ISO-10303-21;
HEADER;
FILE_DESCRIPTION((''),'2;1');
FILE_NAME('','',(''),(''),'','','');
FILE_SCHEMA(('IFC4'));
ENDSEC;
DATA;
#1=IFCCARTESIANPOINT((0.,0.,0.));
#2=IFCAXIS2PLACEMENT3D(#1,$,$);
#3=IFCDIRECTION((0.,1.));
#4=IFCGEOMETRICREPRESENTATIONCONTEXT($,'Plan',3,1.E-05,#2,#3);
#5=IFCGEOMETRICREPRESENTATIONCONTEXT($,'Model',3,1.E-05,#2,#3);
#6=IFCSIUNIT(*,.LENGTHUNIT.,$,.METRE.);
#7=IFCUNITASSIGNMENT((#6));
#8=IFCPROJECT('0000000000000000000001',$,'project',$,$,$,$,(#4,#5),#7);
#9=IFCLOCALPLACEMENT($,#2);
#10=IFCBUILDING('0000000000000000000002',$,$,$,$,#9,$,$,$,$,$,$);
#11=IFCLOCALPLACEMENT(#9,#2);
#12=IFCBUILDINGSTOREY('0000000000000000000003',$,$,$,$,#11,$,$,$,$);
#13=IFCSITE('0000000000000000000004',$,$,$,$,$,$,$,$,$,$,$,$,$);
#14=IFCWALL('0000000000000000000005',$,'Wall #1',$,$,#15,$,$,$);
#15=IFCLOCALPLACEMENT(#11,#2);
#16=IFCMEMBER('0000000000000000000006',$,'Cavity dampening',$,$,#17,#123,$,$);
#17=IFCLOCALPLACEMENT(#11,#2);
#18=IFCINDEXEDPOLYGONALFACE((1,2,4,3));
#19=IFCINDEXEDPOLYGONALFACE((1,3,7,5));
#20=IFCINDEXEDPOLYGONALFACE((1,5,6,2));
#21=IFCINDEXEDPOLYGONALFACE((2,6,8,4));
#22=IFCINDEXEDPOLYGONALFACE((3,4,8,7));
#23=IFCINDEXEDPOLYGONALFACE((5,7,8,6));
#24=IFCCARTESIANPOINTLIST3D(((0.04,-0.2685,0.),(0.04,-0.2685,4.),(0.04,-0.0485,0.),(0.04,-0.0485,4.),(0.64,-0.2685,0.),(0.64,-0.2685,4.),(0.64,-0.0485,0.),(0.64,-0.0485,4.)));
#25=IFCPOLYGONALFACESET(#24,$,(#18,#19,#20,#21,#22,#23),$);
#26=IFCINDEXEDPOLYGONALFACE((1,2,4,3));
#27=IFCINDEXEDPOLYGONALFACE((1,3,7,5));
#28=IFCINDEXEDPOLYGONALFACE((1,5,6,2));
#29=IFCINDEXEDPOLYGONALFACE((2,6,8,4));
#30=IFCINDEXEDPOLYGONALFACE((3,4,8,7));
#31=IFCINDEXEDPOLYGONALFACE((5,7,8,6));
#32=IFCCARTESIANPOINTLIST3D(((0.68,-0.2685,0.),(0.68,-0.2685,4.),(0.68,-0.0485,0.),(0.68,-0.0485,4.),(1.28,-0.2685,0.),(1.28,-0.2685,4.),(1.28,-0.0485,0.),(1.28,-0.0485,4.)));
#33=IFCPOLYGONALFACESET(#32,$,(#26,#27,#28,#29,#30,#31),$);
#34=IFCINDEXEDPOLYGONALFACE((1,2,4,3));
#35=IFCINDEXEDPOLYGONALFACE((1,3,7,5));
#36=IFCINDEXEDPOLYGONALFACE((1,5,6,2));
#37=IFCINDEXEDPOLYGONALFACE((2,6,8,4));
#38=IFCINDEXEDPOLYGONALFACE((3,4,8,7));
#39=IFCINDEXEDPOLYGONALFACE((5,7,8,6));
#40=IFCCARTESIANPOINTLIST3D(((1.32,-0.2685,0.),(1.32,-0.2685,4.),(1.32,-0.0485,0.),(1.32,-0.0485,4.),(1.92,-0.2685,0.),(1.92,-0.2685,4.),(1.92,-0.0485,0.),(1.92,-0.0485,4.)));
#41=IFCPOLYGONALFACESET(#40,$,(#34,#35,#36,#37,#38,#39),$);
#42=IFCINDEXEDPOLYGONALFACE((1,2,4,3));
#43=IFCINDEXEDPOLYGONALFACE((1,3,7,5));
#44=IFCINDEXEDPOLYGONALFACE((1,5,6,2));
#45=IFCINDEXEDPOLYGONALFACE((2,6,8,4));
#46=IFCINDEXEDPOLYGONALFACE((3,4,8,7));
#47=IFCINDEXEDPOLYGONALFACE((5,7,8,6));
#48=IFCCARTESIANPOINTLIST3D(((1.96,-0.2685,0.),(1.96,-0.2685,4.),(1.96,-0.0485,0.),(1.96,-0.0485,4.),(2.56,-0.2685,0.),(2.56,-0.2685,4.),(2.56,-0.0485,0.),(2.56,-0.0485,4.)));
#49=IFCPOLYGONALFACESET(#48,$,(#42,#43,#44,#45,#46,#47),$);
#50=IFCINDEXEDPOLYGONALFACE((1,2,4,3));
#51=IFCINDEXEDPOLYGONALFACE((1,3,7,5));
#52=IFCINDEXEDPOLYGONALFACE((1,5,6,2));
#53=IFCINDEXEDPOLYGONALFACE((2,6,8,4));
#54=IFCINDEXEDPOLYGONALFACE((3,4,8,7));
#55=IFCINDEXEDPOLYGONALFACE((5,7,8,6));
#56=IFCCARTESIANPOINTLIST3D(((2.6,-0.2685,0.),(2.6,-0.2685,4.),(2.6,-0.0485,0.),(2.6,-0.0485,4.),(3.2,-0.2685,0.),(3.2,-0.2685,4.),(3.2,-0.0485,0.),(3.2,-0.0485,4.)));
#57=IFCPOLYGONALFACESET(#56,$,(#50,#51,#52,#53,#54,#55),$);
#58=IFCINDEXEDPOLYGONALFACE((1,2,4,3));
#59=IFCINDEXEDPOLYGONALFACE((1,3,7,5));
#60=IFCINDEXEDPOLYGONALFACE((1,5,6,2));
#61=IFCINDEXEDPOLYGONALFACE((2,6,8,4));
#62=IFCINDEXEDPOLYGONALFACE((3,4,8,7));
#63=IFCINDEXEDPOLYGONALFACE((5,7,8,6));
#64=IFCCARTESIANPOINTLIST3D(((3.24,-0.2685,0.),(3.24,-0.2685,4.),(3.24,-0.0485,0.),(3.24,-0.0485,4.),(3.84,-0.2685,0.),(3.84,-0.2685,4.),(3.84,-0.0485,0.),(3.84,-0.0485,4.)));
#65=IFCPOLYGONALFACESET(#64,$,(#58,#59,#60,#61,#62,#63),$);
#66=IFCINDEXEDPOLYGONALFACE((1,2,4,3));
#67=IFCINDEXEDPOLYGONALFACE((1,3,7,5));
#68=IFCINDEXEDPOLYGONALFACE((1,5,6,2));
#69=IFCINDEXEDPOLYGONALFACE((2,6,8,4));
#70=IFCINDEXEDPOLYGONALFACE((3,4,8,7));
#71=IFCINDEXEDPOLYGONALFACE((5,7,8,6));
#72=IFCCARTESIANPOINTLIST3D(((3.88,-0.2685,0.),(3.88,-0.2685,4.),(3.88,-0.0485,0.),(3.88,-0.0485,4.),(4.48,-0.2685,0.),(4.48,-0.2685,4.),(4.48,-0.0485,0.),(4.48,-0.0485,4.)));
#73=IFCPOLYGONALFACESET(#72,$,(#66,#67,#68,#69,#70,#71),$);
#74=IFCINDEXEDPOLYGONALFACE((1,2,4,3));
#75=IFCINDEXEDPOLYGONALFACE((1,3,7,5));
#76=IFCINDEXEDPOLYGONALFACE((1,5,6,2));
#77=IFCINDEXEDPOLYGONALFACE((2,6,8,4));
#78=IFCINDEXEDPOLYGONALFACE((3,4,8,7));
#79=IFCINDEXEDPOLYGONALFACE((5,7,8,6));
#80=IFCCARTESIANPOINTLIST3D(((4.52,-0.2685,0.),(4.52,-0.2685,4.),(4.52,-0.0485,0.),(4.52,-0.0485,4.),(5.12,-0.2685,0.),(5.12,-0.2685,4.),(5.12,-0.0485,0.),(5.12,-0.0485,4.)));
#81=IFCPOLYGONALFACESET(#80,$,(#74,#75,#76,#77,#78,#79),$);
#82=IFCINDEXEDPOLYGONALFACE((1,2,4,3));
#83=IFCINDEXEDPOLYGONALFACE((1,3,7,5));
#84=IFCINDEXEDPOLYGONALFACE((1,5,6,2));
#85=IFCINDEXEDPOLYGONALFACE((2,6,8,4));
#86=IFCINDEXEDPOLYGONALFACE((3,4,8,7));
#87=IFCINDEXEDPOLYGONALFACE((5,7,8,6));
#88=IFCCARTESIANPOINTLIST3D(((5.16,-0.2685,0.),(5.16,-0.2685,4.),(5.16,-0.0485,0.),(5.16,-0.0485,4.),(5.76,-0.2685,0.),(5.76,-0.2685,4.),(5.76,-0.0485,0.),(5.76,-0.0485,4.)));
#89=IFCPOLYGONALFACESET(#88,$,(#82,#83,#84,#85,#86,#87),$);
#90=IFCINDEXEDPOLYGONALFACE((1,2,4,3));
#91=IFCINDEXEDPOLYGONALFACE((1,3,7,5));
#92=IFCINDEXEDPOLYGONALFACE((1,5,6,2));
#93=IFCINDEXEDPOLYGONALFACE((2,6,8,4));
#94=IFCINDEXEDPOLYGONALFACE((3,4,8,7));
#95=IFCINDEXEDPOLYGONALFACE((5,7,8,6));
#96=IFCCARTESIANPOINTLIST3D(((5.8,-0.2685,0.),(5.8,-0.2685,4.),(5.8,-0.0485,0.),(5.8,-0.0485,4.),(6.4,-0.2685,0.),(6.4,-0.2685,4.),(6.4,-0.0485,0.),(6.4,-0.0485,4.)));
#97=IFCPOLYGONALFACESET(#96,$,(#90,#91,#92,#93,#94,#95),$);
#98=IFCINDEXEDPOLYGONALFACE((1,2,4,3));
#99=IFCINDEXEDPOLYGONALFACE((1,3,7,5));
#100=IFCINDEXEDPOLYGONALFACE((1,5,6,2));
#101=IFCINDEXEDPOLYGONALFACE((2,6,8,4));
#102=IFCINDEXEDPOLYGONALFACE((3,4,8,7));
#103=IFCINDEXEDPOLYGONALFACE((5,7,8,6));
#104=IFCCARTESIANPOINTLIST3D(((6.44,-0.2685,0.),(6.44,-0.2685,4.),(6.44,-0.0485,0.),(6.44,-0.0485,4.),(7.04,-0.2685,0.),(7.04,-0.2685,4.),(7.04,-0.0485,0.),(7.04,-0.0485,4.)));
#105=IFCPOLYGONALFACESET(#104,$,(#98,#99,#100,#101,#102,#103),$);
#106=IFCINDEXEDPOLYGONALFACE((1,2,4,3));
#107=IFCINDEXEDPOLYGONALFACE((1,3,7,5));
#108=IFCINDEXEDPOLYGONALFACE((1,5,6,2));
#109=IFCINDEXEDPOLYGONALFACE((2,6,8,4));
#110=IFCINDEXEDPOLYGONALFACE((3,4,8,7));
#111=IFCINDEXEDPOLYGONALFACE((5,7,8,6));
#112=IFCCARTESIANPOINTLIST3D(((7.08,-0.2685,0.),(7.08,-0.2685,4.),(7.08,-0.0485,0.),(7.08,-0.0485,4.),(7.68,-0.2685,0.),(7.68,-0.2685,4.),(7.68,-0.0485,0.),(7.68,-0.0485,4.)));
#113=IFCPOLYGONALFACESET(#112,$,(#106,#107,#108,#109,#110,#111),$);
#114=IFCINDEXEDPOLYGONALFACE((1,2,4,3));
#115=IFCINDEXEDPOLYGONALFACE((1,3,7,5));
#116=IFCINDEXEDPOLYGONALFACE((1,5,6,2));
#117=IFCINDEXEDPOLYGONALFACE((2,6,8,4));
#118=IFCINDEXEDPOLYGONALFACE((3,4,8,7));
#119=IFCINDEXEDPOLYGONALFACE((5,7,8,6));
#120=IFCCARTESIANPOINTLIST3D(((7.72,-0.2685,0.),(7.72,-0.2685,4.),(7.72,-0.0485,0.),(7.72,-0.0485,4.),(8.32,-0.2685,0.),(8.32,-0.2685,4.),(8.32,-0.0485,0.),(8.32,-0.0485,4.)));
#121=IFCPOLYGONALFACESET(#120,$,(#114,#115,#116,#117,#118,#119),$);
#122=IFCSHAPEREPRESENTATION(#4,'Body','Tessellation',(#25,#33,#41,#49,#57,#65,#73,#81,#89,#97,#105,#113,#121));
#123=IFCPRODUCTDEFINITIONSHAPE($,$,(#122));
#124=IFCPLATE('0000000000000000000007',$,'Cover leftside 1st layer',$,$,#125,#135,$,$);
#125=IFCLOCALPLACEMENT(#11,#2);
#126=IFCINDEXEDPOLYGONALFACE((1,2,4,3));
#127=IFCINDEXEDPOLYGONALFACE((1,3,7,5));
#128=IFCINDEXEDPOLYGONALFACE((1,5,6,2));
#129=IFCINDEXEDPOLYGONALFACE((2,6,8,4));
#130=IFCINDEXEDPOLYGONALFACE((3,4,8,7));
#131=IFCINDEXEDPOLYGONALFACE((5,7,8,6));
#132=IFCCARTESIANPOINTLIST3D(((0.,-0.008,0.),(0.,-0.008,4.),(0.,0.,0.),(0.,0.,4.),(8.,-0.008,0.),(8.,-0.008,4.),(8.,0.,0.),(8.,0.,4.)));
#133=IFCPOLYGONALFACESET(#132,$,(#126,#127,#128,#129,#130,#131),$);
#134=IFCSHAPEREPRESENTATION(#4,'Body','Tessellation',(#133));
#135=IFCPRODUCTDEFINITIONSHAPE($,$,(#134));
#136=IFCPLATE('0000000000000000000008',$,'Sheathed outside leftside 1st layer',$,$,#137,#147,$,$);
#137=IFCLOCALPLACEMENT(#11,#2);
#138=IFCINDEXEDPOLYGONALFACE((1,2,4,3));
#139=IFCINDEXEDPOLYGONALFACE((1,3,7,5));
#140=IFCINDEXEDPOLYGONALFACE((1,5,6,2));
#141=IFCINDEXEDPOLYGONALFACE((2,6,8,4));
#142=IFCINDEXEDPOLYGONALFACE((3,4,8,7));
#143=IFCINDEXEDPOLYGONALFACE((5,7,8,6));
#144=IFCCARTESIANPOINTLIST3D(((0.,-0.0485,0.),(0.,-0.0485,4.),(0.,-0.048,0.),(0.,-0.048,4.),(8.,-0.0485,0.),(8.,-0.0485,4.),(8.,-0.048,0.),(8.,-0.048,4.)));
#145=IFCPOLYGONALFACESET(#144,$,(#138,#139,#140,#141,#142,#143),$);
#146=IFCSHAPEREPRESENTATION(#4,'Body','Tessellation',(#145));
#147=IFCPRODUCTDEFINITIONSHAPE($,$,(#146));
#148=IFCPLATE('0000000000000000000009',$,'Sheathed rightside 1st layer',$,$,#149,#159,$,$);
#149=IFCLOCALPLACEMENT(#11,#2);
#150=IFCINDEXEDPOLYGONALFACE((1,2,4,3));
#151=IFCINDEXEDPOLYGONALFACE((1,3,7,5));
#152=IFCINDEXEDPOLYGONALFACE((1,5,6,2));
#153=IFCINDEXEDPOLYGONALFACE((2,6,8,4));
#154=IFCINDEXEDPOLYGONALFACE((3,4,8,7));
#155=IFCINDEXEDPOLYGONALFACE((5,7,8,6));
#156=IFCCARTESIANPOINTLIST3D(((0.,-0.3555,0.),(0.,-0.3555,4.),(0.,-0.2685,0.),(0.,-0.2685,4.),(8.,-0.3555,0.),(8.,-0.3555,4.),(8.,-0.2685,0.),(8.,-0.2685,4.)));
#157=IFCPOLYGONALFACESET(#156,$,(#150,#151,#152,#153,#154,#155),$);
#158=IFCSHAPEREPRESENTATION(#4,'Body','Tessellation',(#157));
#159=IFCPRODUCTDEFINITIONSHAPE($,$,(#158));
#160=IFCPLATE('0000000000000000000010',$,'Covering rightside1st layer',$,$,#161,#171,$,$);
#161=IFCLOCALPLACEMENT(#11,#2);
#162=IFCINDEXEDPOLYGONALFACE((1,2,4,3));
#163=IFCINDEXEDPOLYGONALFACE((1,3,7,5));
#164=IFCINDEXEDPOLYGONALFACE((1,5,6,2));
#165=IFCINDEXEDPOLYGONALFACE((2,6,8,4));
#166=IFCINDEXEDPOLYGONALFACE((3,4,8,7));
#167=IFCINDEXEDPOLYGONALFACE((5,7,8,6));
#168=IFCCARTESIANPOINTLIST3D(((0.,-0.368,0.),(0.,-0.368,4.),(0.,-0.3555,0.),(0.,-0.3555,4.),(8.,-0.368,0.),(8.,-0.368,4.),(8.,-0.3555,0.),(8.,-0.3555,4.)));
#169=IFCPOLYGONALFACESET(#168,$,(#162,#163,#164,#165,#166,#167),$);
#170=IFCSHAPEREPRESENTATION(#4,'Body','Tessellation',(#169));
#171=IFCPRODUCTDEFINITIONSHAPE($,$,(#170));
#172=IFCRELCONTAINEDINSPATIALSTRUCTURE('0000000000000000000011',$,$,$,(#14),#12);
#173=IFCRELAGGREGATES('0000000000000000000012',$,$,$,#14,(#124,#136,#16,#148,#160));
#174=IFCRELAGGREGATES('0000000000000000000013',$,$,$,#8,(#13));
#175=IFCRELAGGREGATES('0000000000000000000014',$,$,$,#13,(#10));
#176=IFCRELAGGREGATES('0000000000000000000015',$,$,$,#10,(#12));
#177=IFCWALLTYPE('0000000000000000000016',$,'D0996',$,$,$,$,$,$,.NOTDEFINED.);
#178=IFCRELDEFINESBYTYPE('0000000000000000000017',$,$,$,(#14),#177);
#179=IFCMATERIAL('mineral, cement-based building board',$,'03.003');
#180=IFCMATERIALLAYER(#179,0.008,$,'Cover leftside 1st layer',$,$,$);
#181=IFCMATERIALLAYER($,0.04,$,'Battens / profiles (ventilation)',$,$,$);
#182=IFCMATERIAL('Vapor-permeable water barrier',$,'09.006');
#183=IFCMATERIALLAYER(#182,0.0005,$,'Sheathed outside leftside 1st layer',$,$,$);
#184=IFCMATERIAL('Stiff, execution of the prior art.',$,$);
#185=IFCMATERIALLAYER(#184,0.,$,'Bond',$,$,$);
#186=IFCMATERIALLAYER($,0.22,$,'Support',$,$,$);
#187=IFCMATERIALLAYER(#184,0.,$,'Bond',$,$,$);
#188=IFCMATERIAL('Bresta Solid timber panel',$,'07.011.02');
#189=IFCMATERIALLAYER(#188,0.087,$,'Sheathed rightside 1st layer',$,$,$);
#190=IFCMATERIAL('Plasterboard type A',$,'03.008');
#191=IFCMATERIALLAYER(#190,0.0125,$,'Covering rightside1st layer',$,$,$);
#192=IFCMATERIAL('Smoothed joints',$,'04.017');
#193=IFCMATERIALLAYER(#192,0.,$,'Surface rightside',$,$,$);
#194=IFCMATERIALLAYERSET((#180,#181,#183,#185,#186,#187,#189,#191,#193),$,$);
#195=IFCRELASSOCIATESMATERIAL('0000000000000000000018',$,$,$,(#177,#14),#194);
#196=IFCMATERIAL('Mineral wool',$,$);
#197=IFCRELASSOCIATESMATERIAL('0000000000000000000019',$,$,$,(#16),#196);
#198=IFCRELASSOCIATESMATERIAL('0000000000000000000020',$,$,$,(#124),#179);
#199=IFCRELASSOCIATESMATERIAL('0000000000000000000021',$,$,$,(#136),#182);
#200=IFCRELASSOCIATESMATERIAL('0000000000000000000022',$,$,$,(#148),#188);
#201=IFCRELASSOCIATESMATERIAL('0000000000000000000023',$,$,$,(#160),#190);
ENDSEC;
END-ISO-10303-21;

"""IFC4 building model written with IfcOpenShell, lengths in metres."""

from ifc_helpers import new_model, si_unit, direction, frame, frame_2d, origin, origin_with_axes, place, context, project, spatial, rectangle, extrude, material, layer, layer_set, type_object, element, aggregate, save


model = new_model("IFC4")

# Units and contexts
plan_context = context("Plan", 3, precision=1e-05, world=origin(), true_north=direction((0.0, 1.0)))
model_context = context("Model", 3, precision=1e-05, world=origin(), true_north=direction((0.0, 1.0)))
ifc_project = project(units=[si_unit("LENGTHUNIT", "METRE")], contexts=[plan_context, model_context])

# Site, building, storey
site = spatial("IfcSite", under=ifc_project)
building_placement = place(None, origin())
building = spatial("IfcBuilding", under=site, at=building_placement)
storey_placement = place(building_placement, origin())
storey = spatial("IfcBuildingStorey", under=building, at=storey_placement)

# Wall, member, plates
ifc_material_1 = material(Name="mineral, cement-based building board", Category="03.003")
ifc_layer_1 = layer(ifc_material_1, 0.008, Name="Cover leftside 1st layer")
ifc_layer_2 = layer(None, 0.04, Name="Battens / profiles (ventilation)")
ifc_material_2 = material(Name="Vapor-permeable water barrier", Category="09.006")
ifc_layer_3 = layer(ifc_material_2, 0.0005, Name="Sheathed outside leftside 1st layer")
ifc_material_3 = material(Name="Stiff, execution of the prior art.")
ifc_layer_4 = layer(ifc_material_3, 0.0, Name="Bond")
ifc_layer_5 = layer(None, 0.22, Name="Support")
ifc_layer_6 = layer(ifc_material_3, 0.0, Name="Bond")
ifc_material_4 = material(Name="Bresta Solid timber panel", Category="07.011.02")
ifc_layer_7 = layer(ifc_material_4, 0.087, Name="Sheathed rightside 1st layer")
ifc_material_5 = material(Name="Plasterboard type A", Category="03.008")
ifc_layer_8 = layer(ifc_material_5, 0.0125, Name="Covering rightside1st layer")
ifc_material_6 = material(Name="Smoothed joints", Category="04.017")
ifc_layer_9 = layer(ifc_material_6, 0.0, Name="Surface rightside")
ifc_layer_set = layer_set([ifc_layer_1, ifc_layer_2, ifc_layer_3, ifc_layer_4, ifc_layer_5, ifc_layer_6, ifc_layer_7, ifc_layer_8, ifc_layer_9])
wall_type = type_object("IfcWallType", Name="D0996", PredefinedType="NOTDEFINED", material=ifc_layer_set)
wall_placement = place(None, frame((0.0, 0.0, 0.0), z_axis=(0.0, -1.0, 0.0), x_axis=(1.0, 0.0, 0.0)))
wall = element("IfcWall", 1, at=wall_placement, inside=storey, type_object=wall_type, material=ifc_layer_set, Name="Wall #1")
ifc_material_7 = material(Name="Mineral wool")
member_1_placement = place(wall_placement, origin())
member_1 = element("IfcMember", 2, at=member_1_placement, material=ifc_material_7, Name="Cavity dampening", context=plan_context, shape_type="SweptSolid", body=[
    extrude(rectangle(XDim=0.6, YDim=0.22, at=frame_2d((0.3, 0.11), x_axis=(1.0, 0.0))), frame((0.04, 4.0, 0.0485), z_axis=(0.0, -1.0, 0.0), x_axis=(1.0, 0.0, 0.0)), (0.0, 0.0, 1.0), 4.0),
    extrude(rectangle(XDim=0.6, YDim=0.22, at=frame_2d((0.3, 0.11), x_axis=(1.0, 0.0))), frame((0.68, 4.0, 0.0485), z_axis=(0.0, -1.0, 0.0), x_axis=(1.0, 0.0, 0.0)), (0.0, 0.0, 1.0), 4.0),
    extrude(rectangle(XDim=0.6, YDim=0.22, at=frame_2d((0.3, 0.11), x_axis=(1.0, 0.0))), frame((1.32, 4.0, 0.0485), z_axis=(0.0, -1.0, 0.0), x_axis=(1.0, 0.0, 0.0)), (0.0, 0.0, 1.0), 4.0),
    extrude(rectangle(XDim=0.6, YDim=0.22, at=frame_2d((0.3, 0.11), x_axis=(1.0, 0.0))), frame((1.96, 4.0, 0.0485), z_axis=(0.0, -1.0, 0.0), x_axis=(1.0, 0.0, 0.0)), (0.0, 0.0, 1.0), 4.0),
    extrude(rectangle(XDim=0.6, YDim=0.22, at=frame_2d((0.3, 0.11), x_axis=(1.0, 0.0))), frame((2.6, 4.0, 0.0485), z_axis=(0.0, -1.0, 0.0), x_axis=(1.0, 0.0, 0.0)), (0.0, 0.0, 1.0), 4.0),
    extrude(rectangle(XDim=0.6, YDim=0.22, at=frame_2d((0.3, 0.11), x_axis=(1.0, 0.0))), frame((3.24, 4.0, 0.0485), z_axis=(0.0, -1.0, 0.0), x_axis=(1.0, 0.0, 0.0)), (0.0, 0.0, 1.0), 4.0),
    extrude(rectangle(XDim=0.6, YDim=0.22, at=frame_2d((0.3, 0.11), x_axis=(1.0, 0.0))), frame((3.88, 4.0, 0.0485), z_axis=(0.0, -1.0, 0.0), x_axis=(1.0, 0.0, 0.0)), (0.0, 0.0, 1.0), 4.0),
    extrude(rectangle(XDim=0.6, YDim=0.22, at=frame_2d((0.3, 0.11), x_axis=(1.0, 0.0))), frame((4.52, 4.0, 0.0485), z_axis=(0.0, -1.0, 0.0), x_axis=(1.0, 0.0, 0.0)), (0.0, 0.0, 1.0), 4.0),
    extrude(rectangle(XDim=0.6, YDim=0.22, at=frame_2d((0.3, 0.11), x_axis=(1.0, 0.0))), frame((5.16, 4.0, 0.0485), z_axis=(0.0, -1.0, 0.0), x_axis=(1.0, 0.0, 0.0)), (0.0, 0.0, 1.0), 4.0),
    extrude(rectangle(XDim=0.6, YDim=0.22, at=frame_2d((0.3, 0.11), x_axis=(1.0, 0.0))), frame((5.8, 4.0, 0.0485), z_axis=(0.0, -1.0, 0.0), x_axis=(1.0, 0.0, 0.0)), (0.0, 0.0, 1.0), 4.0),
    extrude(rectangle(XDim=0.6, YDim=0.22, at=frame_2d((0.3, 0.11), x_axis=(1.0, 0.0))), frame((6.44, 4.0, 0.0485), z_axis=(0.0, -1.0, 0.0), x_axis=(1.0, 0.0, 0.0)), (0.0, 0.0, 1.0), 4.0),
    extrude(rectangle(XDim=0.6, YDim=0.22, at=frame_2d((0.3, 0.11), x_axis=(1.0, 0.0))), frame((7.08, 4.0, 0.0485), z_axis=(0.0, -1.0, 0.0), x_axis=(1.0, 0.0, 0.0)), (0.0, 0.0, 1.0), 4.0),
    extrude(rectangle(XDim=0.6, YDim=0.22, at=frame_2d((0.3, 0.11), x_axis=(1.0, 0.0))), frame((7.72, 4.0, 0.0485), z_axis=(0.0, -1.0, 0.0), x_axis=(1.0, 0.0, 0.0)), (0.0, 0.0, 1.0), 4.0),
])
plate_1_placement = place(wall_placement, origin())
plate_1 = element("IfcPlate", 3, at=plate_1_placement, material=ifc_material_1, Name="Cover leftside 1st layer", context=plan_context, shape_type="SweptSolid", body=[
    extrude(rectangle(XDim=8.0, YDim=4.0, at=frame_2d((4.0, 2.0), x_axis=(1.0, 0.0))), origin_with_axes(), (0.0, 0.0, 1.0), 0.008),
])
plate_2_placement = place(wall_placement, origin())
plate_2 = element("IfcPlate", 4, at=plate_2_placement, material=ifc_material_2, Name="Sheathed outside leftside 1st layer", context=plan_context, shape_type="SweptSolid", body=[
    extrude(rectangle(XDim=8.0, YDim=4.0, at=frame_2d((4.0, 2.0), x_axis=(1.0, 0.0))), frame((0.0, 0.0, 0.048), z_axis=(0.0, 0.0, 1.0), x_axis=(1.0, 0.0, 0.0)), (0.0, 0.0, 1.0), 0.0005),
])
plate_3_placement = place(wall_placement, origin())
plate_3 = element("IfcPlate", 5, at=plate_3_placement, material=ifc_material_4, Name="Sheathed rightside 1st layer", context=plan_context, shape_type="SweptSolid", body=[
    extrude(rectangle(XDim=8.0, YDim=4.0, at=frame_2d((4.0, 2.0), x_axis=(1.0, 0.0))), frame((0.0, 0.0, 0.2685), z_axis=(0.0, 0.0, 1.0), x_axis=(1.0, 0.0, 0.0)), (0.0, 0.0, 1.0), 0.087),
])
plate_4_placement = place(wall_placement, origin())
plate_4 = element("IfcPlate", 6, at=plate_4_placement, material=ifc_material_5, Name="Covering rightside1st layer", context=plan_context, shape_type="SweptSolid", body=[
    extrude(rectangle(XDim=8.0, YDim=4.0, at=frame_2d((4.0, 2.0), x_axis=(1.0, 0.0))), frame((0.0, 0.0, 0.3555), z_axis=(0.0, 0.0, 1.0), x_axis=(1.0, 0.0, 0.0)), (0.0, 0.0, 1.0), 0.0125),
])
aggregate(wall, [plate_1, plate_2, member_1, plate_3, plate_4])

save(model, "model.ifc")
